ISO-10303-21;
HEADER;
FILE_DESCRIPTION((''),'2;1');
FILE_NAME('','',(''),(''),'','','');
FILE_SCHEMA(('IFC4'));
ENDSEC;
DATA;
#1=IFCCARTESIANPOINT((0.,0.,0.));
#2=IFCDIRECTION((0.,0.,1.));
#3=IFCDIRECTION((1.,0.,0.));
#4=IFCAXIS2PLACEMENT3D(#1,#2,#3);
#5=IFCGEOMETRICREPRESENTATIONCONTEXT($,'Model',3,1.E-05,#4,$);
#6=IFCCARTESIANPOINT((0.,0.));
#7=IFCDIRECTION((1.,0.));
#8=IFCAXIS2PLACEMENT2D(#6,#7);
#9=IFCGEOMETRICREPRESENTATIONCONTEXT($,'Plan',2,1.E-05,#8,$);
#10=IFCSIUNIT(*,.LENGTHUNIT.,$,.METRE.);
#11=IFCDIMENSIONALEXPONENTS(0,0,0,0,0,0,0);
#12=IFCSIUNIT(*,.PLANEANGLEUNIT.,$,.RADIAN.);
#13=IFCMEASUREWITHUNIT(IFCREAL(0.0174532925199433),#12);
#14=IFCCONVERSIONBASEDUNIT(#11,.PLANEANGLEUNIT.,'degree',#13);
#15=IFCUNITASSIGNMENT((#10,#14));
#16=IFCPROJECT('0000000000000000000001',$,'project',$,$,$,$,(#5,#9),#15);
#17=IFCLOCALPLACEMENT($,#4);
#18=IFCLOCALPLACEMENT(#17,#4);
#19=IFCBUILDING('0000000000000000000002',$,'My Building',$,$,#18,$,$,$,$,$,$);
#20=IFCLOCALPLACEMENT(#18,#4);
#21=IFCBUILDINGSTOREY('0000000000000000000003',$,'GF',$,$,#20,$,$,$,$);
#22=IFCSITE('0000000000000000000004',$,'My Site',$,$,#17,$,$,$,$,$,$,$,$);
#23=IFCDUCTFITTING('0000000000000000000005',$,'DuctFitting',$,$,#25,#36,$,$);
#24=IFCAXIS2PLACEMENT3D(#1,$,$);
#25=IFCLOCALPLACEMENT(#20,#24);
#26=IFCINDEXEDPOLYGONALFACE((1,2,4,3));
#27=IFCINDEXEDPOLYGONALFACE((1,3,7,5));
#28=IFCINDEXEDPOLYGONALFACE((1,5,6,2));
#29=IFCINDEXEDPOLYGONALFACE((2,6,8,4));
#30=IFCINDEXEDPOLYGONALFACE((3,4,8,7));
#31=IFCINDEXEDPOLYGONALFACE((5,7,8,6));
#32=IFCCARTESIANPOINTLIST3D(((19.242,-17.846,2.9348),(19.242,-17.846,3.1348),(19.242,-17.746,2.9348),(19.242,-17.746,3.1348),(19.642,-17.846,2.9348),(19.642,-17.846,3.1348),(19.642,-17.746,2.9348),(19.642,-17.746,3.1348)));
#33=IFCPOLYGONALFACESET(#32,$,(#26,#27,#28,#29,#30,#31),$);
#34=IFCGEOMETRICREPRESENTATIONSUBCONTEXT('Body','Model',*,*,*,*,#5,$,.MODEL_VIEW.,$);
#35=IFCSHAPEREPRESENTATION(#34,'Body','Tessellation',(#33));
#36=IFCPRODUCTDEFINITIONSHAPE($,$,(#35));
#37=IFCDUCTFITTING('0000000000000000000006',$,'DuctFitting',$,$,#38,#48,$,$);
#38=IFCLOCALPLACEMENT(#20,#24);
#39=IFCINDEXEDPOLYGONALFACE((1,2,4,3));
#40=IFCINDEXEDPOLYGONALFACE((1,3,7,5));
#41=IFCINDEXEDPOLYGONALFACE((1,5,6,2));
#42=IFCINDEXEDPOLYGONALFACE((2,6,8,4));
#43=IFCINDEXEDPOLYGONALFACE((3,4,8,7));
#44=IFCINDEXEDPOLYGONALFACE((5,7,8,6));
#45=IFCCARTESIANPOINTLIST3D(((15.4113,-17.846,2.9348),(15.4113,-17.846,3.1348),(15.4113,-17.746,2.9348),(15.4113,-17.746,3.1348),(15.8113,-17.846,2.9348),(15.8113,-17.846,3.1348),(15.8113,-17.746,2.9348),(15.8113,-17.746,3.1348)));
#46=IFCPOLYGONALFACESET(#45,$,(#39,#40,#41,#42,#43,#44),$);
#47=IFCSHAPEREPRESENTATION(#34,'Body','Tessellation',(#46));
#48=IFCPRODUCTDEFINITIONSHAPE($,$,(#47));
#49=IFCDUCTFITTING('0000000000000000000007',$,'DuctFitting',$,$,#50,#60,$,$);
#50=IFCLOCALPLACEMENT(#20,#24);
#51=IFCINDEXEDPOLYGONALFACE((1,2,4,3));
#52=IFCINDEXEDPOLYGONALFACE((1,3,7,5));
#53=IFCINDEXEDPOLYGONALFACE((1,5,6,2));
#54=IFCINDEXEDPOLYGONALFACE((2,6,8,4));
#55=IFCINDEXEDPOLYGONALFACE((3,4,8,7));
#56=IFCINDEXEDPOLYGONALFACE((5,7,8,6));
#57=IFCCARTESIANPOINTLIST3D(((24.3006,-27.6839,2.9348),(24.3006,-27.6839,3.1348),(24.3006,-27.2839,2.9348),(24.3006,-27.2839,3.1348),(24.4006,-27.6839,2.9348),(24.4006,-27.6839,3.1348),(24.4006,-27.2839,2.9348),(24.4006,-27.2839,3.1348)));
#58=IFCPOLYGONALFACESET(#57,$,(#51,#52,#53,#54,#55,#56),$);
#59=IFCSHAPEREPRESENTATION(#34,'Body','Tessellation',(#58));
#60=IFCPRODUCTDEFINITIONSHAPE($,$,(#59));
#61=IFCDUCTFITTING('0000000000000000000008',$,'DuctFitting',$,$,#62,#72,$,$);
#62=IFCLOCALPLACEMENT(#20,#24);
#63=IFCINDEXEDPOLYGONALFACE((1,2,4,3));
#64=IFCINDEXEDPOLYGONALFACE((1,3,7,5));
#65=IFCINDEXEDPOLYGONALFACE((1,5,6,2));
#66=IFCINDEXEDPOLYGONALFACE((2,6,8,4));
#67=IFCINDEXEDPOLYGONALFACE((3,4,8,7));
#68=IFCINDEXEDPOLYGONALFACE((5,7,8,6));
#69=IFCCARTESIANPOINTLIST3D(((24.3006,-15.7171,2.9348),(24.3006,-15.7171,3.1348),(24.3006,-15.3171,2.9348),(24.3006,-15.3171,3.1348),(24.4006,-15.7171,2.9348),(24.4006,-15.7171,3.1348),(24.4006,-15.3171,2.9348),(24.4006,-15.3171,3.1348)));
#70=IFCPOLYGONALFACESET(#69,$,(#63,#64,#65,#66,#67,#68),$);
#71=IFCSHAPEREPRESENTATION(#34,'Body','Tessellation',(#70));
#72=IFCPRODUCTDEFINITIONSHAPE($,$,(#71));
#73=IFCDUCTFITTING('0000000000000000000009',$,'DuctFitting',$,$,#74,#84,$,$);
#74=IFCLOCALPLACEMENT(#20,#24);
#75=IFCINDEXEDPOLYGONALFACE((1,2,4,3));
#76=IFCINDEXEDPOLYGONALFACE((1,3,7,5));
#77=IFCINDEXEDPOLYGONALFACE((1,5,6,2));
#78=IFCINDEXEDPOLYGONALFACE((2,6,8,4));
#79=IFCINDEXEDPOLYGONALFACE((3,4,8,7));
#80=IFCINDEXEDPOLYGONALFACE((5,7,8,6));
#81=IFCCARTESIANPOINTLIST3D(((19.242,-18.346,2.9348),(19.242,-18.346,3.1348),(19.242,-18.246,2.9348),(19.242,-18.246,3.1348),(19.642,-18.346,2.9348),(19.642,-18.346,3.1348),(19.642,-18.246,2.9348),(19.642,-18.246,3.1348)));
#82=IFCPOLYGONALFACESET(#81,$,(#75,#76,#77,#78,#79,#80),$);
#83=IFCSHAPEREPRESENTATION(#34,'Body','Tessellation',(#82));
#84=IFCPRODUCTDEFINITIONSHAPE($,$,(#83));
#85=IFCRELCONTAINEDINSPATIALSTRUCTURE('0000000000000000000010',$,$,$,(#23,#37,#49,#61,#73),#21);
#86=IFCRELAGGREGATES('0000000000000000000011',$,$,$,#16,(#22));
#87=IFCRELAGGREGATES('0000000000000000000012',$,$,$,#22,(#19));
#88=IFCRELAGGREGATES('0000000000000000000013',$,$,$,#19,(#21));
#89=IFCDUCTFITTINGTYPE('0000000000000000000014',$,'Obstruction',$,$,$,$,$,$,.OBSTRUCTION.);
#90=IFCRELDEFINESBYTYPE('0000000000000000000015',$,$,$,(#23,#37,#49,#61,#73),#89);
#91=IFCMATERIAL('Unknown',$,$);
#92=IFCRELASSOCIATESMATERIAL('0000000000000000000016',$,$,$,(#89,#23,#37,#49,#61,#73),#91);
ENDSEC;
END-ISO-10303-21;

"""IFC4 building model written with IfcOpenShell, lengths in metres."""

from ifc_helpers import new_model, entity, si_unit, converted_unit, frame, origin_with_axes, origin_2d_with_axis, place, context, subcontext, project, spatial, rectangle, extrude, material, material_profile, profile_set, profile_usage, type_object, element, save


model = new_model("IFC4")

# Units and contexts
model_context = context("Model", 3, precision=1e-05, world=origin_with_axes())
plan_context = context("Plan", 2, precision=1e-05, world=origin_2d_with_axis())
body_context_1 = subcontext(model_context, "Body", "Model", "MODEL_VIEW")
ifc_project = project(units=[si_unit("LENGTHUNIT", "METRE"), converted_unit("PLANEANGLEUNIT", "degree", entity("IfcReal", 0.0174532925199433), si_unit("PLANEANGLEUNIT", "RADIAN"), dimensions=[0, 0, 0, 0, 0, 0, 0])], contexts=[model_context, plan_context])

# Site, building, storey
site_placement = place(None, origin_with_axes())
site = spatial("IfcSite", under=ifc_project, at=site_placement, Name="My Site")
building_placement = place(site_placement, origin_with_axes())
building = spatial("IfcBuilding", under=site, at=building_placement, Name="My Building")
storey_placement = place(building_placement, origin_with_axes())
storey = spatial("IfcBuildingStorey", under=building, at=storey_placement, Name="GF")

# Shared definitions
ifc_material = material(Name="Unknown")

# Duct fittings
ifc_material_profile_1 = material_profile(ifc_material, rectangle(XDim=0.4, YDim=0.2))
ifc_profile_set_1 = profile_set([ifc_material_profile_1])
duct_fitting_type_1 = type_object("IfcDuctFittingType", Name="Obstruction", PredefinedType="OBSTRUCTION", material=ifc_profile_set_1)
ifc_profile_usage_1 = profile_usage(ifc_profile_set_1, cardinal=5)
duct_fitting_1_placement = place(storey_placement, frame((19.442, -17.746, 3.0348), z_axis=(0.0, -1.0, 0.000001), x_axis=(1.0, 0.0, 0.0)))
element("IfcDuctFitting", 1, at=duct_fitting_1_placement, inside=storey, type_object=duct_fitting_type_1, material=ifc_profile_usage_1, Name="DuctFitting", context=body_context_1, shape_type="SweptSolid", body=[
    extrude(rectangle(XDim=0.4, YDim=0.2), origin_with_axes(), (0.0, 0.0, 1.0), 0.1),
])
ifc_profile_usage_2 = profile_usage(ifc_profile_set_1, cardinal=5)
duct_fitting_2_placement = place(storey_placement, frame((15.6113, -17.746, 3.0348), z_axis=(0.0, -1.0, 0.000001), x_axis=(1.0, 0.0, 0.0)))
element("IfcDuctFitting", 2, at=duct_fitting_2_placement, inside=storey, type_object=duct_fitting_type_1, material=ifc_profile_usage_2, Name="DuctFitting", context=body_context_1, shape_type="SweptSolid", body=[
    extrude(rectangle(XDim=0.4, YDim=0.2), origin_with_axes(), (0.0, 0.0, 1.0), 0.1),
])
ifc_profile_usage_3 = profile_usage(ifc_profile_set_1, cardinal=5)
duct_fitting_3_placement = place(storey_placement, frame((24.3006, -27.4839, 3.0348), z_axis=(1.0, 0.0, 0.0), x_axis=(0.0, 1.0, 0.0)))
element("IfcDuctFitting", 3, at=duct_fitting_3_placement, inside=storey, type_object=duct_fitting_type_1, material=ifc_profile_usage_3, Name="DuctFitting", context=body_context_1, shape_type="SweptSolid", body=[
    extrude(rectangle(XDim=0.4, YDim=0.2), origin_with_axes(), (0.0, 0.0, 1.0), 0.1),
])
ifc_profile_usage_4 = profile_usage(ifc_profile_set_1, cardinal=5)
duct_fitting_4_placement = place(storey_placement, frame((24.3006, -15.5171, 3.0348), z_axis=(1.0, 0.0, 0.0), x_axis=(0.0, 1.0, 0.0)))
element("IfcDuctFitting", 4, at=duct_fitting_4_placement, inside=storey, type_object=duct_fitting_type_1, material=ifc_profile_usage_4, Name="DuctFitting", context=body_context_1, shape_type="SweptSolid", body=[
    extrude(rectangle(XDim=0.4, YDim=0.2), origin_with_axes(), (0.0, 0.0, 1.0), 0.1),
])
ifc_profile_usage_5 = profile_usage(ifc_profile_set_1, cardinal=5)
duct_fitting_5_placement = place(storey_placement, frame((19.442, -18.246, 3.0348), z_axis=(0.0, -1.0, 0.000001), x_axis=(1.0, 0.0, 0.0)))
element("IfcDuctFitting", 5, at=duct_fitting_5_placement, inside=storey, type_object=duct_fitting_type_1, material=ifc_profile_usage_5, Name="DuctFitting", context=body_context_1, shape_type="SweptSolid", body=[
    extrude(rectangle(XDim=0.4, YDim=0.2), origin_with_axes(), (0.0, 0.0, 1.0), 0.1),
])

save(model, "model.ifc")
